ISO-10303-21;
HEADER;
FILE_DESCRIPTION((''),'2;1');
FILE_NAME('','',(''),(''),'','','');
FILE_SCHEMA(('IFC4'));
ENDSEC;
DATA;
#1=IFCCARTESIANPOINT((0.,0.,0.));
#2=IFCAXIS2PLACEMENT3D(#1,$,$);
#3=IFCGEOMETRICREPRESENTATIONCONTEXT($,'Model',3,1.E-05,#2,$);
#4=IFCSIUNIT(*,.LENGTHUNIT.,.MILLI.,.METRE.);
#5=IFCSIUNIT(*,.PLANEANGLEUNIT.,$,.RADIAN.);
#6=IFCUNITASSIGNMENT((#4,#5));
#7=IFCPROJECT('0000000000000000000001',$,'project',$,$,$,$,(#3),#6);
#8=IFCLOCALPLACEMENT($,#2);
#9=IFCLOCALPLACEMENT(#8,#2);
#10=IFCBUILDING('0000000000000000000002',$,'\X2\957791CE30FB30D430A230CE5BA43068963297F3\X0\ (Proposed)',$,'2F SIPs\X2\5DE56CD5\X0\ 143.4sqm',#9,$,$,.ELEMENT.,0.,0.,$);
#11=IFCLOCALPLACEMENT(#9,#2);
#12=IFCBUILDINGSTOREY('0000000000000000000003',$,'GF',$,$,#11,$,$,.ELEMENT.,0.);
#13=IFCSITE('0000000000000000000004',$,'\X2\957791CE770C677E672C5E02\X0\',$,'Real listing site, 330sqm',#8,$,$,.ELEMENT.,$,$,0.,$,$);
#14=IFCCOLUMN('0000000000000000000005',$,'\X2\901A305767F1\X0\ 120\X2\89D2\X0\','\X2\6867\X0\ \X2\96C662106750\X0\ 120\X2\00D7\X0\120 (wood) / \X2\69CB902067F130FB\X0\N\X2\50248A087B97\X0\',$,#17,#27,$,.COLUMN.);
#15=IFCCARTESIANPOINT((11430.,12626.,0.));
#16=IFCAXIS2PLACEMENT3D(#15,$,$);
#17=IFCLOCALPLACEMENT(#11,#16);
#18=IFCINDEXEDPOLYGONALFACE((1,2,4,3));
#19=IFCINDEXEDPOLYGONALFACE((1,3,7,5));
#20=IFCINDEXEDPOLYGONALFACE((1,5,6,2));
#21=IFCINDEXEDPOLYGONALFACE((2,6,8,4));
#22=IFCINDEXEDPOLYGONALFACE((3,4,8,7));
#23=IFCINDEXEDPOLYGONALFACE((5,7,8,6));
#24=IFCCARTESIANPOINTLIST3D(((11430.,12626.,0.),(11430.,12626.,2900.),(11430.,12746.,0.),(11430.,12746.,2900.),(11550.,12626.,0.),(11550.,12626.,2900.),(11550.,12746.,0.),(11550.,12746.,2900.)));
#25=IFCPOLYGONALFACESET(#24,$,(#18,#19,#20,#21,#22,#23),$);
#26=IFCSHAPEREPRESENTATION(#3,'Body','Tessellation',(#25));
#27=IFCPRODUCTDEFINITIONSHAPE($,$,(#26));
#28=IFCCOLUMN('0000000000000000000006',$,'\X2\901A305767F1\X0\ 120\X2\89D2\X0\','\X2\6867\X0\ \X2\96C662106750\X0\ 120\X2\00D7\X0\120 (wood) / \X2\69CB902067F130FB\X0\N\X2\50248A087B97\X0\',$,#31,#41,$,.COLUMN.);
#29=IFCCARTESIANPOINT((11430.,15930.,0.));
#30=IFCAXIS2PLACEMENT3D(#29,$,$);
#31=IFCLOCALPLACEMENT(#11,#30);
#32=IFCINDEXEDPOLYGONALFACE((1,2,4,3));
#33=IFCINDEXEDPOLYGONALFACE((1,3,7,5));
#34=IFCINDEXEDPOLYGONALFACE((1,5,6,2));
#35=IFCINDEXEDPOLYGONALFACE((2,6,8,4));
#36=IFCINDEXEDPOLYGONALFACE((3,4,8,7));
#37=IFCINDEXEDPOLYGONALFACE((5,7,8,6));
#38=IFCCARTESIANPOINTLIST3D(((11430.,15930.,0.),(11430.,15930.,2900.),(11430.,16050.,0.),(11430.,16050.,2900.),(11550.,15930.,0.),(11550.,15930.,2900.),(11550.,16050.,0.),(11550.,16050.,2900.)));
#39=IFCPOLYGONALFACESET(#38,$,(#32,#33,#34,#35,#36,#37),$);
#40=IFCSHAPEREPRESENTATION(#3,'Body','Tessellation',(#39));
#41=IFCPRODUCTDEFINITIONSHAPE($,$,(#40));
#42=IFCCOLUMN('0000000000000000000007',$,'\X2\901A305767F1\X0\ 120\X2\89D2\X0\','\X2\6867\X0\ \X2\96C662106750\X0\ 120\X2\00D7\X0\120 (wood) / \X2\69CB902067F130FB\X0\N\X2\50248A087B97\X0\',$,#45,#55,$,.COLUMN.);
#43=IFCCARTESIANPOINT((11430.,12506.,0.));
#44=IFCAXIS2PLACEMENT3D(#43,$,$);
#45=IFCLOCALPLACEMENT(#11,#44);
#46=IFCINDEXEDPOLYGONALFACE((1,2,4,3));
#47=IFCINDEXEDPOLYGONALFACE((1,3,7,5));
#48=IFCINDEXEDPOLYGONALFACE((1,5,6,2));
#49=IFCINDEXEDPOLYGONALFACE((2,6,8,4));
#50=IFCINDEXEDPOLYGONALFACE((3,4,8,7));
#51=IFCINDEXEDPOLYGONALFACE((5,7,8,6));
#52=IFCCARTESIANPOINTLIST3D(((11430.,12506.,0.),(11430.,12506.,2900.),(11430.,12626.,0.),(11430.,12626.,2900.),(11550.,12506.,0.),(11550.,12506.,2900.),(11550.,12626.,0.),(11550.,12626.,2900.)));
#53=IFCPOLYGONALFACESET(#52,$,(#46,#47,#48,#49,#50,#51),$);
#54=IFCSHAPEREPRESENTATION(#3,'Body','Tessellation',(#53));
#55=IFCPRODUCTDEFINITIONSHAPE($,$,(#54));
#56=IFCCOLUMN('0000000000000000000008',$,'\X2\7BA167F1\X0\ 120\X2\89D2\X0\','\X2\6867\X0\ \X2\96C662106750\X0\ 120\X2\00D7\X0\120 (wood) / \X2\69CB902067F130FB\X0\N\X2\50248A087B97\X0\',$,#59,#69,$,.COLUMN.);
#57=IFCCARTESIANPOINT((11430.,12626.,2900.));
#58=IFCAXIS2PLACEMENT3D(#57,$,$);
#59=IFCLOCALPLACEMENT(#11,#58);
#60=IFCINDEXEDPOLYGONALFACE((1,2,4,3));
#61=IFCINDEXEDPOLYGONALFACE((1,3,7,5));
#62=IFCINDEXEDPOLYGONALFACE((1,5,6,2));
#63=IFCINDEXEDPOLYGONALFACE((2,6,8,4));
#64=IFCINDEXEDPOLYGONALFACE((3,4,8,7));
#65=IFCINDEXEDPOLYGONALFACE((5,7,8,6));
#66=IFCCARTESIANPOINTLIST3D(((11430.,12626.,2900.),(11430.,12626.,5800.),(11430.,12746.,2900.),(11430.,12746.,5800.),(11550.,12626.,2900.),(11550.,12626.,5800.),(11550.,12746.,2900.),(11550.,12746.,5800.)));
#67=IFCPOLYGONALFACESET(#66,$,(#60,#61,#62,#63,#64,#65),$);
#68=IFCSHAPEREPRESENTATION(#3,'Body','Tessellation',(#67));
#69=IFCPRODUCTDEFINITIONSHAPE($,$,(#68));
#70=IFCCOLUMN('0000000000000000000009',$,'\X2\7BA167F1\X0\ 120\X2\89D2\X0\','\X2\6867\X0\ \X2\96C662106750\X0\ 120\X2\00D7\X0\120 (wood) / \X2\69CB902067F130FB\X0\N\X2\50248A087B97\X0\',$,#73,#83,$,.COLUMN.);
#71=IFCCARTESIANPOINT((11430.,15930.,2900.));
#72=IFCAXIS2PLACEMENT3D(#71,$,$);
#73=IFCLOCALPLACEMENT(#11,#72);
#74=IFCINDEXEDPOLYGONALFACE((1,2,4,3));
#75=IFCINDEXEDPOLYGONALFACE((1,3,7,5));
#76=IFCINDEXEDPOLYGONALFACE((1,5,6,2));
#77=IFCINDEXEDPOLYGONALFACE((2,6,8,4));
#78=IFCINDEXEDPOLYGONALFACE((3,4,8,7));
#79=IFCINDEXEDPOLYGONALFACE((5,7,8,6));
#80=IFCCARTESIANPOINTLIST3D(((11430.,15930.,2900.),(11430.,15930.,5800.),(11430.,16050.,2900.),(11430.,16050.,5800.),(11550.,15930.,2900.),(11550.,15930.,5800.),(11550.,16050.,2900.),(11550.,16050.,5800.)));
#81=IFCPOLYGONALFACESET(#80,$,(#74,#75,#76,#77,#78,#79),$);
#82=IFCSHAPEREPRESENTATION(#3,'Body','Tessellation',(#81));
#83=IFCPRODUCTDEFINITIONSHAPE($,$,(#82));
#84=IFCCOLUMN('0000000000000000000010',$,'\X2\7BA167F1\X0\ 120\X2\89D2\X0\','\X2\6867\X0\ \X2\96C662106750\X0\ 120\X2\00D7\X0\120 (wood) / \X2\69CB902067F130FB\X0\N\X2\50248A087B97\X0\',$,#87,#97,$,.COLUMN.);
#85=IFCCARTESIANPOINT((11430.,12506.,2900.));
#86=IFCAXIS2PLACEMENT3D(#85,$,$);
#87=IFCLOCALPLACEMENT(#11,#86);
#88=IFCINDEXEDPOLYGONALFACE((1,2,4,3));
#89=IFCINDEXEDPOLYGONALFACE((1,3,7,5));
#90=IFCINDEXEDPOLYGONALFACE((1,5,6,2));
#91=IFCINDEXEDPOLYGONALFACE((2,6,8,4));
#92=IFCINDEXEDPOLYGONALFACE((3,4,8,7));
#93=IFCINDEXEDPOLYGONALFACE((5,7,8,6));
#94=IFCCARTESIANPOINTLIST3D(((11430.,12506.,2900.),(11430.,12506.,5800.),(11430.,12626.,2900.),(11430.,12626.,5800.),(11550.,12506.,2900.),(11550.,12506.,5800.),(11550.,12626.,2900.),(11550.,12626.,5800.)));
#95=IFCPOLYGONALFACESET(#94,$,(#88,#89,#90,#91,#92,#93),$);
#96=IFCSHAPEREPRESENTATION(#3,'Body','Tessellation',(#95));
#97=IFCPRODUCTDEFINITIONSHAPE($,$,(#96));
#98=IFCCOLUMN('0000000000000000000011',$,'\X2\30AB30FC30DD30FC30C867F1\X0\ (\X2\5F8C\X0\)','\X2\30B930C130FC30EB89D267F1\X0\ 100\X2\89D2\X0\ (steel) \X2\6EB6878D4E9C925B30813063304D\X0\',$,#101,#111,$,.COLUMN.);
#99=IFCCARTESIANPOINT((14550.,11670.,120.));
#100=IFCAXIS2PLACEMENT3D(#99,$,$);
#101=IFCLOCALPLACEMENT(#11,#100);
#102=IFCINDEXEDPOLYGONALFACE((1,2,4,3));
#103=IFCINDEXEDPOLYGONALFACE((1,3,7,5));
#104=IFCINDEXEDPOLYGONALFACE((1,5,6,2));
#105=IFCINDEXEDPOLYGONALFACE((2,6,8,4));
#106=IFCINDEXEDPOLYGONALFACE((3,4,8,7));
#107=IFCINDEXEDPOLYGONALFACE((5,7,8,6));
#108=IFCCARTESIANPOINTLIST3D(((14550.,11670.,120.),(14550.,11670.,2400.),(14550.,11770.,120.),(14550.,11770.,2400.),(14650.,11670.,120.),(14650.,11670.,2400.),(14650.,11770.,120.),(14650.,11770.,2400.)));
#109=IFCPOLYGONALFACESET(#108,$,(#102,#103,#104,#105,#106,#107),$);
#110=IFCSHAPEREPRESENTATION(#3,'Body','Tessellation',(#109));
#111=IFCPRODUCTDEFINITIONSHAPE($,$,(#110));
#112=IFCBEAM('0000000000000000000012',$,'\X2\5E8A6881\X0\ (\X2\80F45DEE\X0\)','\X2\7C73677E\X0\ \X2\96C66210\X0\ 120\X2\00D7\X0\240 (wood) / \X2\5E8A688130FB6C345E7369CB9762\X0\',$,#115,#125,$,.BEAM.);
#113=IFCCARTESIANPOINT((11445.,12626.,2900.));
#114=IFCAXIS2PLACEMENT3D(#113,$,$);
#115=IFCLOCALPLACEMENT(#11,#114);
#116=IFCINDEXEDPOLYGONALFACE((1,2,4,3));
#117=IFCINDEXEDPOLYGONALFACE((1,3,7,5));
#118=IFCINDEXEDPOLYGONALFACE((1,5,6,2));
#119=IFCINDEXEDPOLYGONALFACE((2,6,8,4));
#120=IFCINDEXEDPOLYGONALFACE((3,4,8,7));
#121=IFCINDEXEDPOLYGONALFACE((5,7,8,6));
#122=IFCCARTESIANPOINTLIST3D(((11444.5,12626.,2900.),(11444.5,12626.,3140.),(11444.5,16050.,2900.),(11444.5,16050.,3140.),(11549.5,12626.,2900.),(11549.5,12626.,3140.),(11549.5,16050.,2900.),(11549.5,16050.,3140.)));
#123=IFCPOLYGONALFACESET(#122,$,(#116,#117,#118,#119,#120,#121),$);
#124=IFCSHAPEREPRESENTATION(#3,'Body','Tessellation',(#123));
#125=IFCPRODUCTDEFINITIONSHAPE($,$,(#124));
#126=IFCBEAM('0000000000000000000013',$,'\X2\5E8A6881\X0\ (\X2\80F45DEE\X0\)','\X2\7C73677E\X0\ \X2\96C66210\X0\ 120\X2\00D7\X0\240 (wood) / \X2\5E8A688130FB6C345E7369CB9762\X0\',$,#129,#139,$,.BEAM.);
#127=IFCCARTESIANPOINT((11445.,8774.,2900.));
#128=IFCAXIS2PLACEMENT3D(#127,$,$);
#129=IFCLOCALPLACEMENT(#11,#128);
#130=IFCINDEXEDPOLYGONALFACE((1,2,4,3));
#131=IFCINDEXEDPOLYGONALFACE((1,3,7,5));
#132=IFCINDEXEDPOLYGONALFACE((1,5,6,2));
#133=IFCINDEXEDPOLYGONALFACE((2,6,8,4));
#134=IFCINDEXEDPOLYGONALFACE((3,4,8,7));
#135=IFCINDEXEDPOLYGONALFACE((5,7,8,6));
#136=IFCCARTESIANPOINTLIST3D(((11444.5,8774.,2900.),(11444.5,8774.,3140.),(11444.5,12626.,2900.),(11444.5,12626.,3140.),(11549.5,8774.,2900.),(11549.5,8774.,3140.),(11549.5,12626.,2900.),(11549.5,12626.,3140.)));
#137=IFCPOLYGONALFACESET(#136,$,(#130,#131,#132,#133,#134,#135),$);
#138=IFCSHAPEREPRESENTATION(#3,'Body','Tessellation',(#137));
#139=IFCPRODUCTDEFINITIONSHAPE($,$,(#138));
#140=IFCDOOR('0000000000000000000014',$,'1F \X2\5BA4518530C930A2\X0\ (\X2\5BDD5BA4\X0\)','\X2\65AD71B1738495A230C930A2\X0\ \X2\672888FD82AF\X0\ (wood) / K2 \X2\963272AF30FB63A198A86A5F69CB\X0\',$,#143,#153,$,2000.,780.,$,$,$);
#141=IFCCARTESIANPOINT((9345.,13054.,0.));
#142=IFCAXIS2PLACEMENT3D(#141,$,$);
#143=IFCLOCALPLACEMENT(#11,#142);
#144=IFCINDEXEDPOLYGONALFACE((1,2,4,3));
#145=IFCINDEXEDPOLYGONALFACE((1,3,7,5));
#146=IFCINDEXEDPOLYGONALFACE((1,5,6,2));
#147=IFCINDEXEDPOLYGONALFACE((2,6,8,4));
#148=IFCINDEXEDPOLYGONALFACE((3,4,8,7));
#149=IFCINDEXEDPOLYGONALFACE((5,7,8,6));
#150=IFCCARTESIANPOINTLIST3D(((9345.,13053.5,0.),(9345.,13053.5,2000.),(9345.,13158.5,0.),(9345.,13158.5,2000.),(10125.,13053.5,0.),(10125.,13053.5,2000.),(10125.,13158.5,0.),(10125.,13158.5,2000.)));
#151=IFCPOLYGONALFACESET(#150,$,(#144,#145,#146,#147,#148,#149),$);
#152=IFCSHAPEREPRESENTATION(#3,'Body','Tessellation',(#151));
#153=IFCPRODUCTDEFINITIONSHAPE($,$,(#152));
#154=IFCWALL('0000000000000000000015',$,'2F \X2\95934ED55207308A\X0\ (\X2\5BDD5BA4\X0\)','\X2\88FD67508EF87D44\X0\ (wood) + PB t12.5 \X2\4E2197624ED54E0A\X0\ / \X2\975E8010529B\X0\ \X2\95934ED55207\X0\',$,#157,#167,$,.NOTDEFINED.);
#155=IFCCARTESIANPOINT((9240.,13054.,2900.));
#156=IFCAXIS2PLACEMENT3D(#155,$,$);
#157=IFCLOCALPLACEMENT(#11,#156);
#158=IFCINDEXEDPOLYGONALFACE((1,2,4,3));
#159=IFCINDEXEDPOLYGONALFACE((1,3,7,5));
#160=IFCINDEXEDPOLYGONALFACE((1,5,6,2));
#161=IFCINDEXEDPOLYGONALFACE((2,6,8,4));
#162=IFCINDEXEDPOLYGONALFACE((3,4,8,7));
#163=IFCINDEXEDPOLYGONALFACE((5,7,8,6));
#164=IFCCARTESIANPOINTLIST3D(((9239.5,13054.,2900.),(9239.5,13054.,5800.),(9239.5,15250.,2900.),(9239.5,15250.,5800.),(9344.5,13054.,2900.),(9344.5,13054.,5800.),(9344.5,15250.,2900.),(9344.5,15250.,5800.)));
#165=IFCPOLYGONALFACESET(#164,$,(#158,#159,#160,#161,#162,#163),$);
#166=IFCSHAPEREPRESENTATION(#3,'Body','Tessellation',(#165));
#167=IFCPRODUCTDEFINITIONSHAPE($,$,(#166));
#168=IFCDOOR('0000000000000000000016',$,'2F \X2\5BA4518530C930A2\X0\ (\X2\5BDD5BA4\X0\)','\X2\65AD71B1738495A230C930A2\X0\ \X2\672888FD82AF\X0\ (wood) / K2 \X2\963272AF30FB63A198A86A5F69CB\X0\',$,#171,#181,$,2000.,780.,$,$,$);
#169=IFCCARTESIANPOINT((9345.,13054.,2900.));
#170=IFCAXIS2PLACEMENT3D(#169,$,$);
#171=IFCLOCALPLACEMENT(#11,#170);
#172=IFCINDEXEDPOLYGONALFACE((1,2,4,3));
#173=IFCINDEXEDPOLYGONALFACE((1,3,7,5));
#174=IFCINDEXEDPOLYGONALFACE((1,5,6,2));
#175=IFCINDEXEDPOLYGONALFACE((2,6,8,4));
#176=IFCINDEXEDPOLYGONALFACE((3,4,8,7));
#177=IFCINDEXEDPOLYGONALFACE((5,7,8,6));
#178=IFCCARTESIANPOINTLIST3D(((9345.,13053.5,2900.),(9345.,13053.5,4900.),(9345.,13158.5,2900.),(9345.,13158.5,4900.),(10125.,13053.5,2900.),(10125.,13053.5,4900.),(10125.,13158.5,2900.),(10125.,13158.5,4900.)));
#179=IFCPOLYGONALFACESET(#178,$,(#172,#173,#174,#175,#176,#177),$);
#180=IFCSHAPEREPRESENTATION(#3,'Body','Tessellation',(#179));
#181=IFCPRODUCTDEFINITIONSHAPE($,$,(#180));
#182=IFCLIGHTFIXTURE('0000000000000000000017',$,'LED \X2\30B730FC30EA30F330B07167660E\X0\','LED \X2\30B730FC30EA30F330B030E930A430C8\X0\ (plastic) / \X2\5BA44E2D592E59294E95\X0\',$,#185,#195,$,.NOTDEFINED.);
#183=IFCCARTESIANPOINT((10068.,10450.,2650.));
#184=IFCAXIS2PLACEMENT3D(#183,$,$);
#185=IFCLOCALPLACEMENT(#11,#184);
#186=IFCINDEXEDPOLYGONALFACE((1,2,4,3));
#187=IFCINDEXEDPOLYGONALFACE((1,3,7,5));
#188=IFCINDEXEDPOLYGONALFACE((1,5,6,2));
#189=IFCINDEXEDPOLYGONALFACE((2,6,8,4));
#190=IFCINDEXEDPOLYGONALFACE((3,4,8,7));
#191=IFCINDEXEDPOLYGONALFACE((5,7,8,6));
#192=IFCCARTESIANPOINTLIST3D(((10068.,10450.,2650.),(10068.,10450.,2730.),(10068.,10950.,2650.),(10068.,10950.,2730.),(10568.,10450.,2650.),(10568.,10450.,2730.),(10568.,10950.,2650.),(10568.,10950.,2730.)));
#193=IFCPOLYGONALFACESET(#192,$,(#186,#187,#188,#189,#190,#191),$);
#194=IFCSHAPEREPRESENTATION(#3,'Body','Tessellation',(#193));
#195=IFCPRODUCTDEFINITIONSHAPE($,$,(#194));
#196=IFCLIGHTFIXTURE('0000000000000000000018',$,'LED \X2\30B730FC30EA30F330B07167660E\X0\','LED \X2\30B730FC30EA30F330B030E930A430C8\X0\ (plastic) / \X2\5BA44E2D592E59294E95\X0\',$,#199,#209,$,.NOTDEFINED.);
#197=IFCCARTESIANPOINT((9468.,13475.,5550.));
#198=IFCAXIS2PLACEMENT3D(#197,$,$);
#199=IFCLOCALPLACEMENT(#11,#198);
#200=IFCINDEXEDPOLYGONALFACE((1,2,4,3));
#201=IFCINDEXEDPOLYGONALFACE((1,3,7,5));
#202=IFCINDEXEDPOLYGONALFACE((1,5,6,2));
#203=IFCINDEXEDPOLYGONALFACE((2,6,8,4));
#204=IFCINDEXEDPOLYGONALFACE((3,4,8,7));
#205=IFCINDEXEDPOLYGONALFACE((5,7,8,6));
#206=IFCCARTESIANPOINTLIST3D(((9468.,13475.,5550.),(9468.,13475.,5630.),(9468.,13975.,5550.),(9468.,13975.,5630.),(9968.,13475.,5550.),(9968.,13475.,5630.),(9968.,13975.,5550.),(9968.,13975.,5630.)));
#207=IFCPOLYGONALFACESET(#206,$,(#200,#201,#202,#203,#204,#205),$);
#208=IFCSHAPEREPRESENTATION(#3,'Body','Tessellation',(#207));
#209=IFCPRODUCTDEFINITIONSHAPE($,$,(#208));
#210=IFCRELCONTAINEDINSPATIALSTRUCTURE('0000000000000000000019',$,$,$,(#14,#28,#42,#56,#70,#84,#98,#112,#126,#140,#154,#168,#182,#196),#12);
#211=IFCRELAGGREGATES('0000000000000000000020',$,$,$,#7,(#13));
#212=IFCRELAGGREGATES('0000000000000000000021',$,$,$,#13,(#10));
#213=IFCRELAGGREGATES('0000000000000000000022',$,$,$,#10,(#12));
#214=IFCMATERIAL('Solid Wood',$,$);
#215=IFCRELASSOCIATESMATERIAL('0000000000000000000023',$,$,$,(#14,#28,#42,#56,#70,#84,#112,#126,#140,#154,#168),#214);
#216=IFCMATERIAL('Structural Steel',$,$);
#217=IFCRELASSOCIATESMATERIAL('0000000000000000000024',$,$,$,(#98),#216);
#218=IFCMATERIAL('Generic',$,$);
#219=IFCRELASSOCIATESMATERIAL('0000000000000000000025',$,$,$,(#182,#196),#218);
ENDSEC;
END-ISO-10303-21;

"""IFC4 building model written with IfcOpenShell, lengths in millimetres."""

from ifc_helpers import new_model, si_unit, frame, frame_2d, origin, place, context, project, spatial, rectangle, extrude, material, element, save


model = new_model("IFC4")

# Units and contexts
model_context = context("Model", 3, precision=1e-05, world=origin())
ifc_project = project(units=[si_unit("LENGTHUNIT", "METRE", prefix="MILLI"), si_unit("PLANEANGLEUNIT", "RADIAN")], contexts=[model_context])

# Site, building, storey
site_placement = place(None, origin())
site = spatial("IfcSite", under=ifc_project, at=site_placement, Name="長野県松本市", ObjectType="Real listing site, 330sqm", CompositionType="ELEMENT", RefElevation=0.0)
building_placement = place(site_placement, origin())
building = spatial("IfcBuilding", under=site, at=building_placement, Name="長野・ピアノ室と防音 (Proposed)", ObjectType="2F SIPs工法 143.4sqm", CompositionType="ELEMENT", ElevationOfRefHeight=0.0, ElevationOfTerrain=0.0)
storey_placement = place(building_placement, origin())
storey = spatial("IfcBuildingStorey", under=building, at=storey_placement, Name="GF", CompositionType="ELEMENT", Elevation=0.0)

# Columns
ifc_material_1 = material(Name="Solid Wood")
column_1_placement = place(storey_placement, frame((11430.0, 12626.0, 0.0)))
element("IfcColumn", 1, at=column_1_placement, inside=storey, material=ifc_material_1, Name="通し柱 120角", Description="桧 集成材 120×120 (wood) / 構造柱・N値計算", PredefinedType="COLUMN", context=model_context, shape_type="SweptSolid", body=[
    extrude(rectangle(XDim=120.0, YDim=120.0, at=frame_2d((60.0, 60.0))), frame((11430.0, 12626.0, 0.0)), (0.0, 0.0, 1.0), 2900.0),
])
column_2_placement = place(storey_placement, frame((11430.0, 15930.0, 0.0)))
element("IfcColumn", 2, at=column_2_placement, inside=storey, material=ifc_material_1, Name="通し柱 120角", Description="桧 集成材 120×120 (wood) / 構造柱・N値計算", PredefinedType="COLUMN", context=model_context, shape_type="SweptSolid", body=[
    extrude(rectangle(XDim=120.0, YDim=120.0, at=frame_2d((60.0, 60.0))), frame((11430.0, 15930.0, 0.0)), (0.0, 0.0, 1.0), 2900.0),
])
column_3_placement = place(storey_placement, frame((11430.0, 12506.0, 0.0)))
element("IfcColumn", 3, at=column_3_placement, inside=storey, material=ifc_material_1, Name="通し柱 120角", Description="桧 集成材 120×120 (wood) / 構造柱・N値計算", PredefinedType="COLUMN", context=model_context, shape_type="SweptSolid", body=[
    extrude(rectangle(XDim=120.0, YDim=120.0, at=frame_2d((60.0, 60.0))), frame((11430.0, 12506.0, 0.0)), (0.0, 0.0, 1.0), 2900.0),
])
column_4_placement = place(storey_placement, frame((11430.0, 12626.0, 2900.0)))
element("IfcColumn", 4, at=column_4_placement, inside=storey, material=ifc_material_1, Name="管柱 120角", Description="桧 集成材 120×120 (wood) / 構造柱・N値計算", PredefinedType="COLUMN", context=model_context, shape_type="SweptSolid", body=[
    extrude(rectangle(XDim=120.0, YDim=120.0, at=frame_2d((60.0, 60.0))), frame((11430.0, 12626.0, 2900.0)), (0.0, 0.0, 1.0), 2900.0),
])
column_5_placement = place(storey_placement, frame((11430.0, 15930.0, 2900.0)))
element("IfcColumn", 5, at=column_5_placement, inside=storey, material=ifc_material_1, Name="管柱 120角", Description="桧 集成材 120×120 (wood) / 構造柱・N値計算", PredefinedType="COLUMN", context=model_context, shape_type="SweptSolid", body=[
    extrude(rectangle(XDim=120.0, YDim=120.0, at=frame_2d((60.0, 60.0))), frame((11430.0, 15930.0, 2900.0)), (0.0, 0.0, 1.0), 2900.0),
])
column_6_placement = place(storey_placement, frame((11430.0, 12506.0, 2900.0)))
element("IfcColumn", 6, at=column_6_placement, inside=storey, material=ifc_material_1, Name="管柱 120角", Description="桧 集成材 120×120 (wood) / 構造柱・N値計算", PredefinedType="COLUMN", context=model_context, shape_type="SweptSolid", body=[
    extrude(rectangle(XDim=120.0, YDim=120.0, at=frame_2d((60.0, 60.0))), frame((11430.0, 12506.0, 2900.0)), (0.0, 0.0, 1.0), 2900.0),
])
ifc_material_2 = material(Name="Structural Steel")
column_7_placement = place(storey_placement, frame((14550.0, 11670.0, 120.0)))
element("IfcColumn", 7, at=column_7_placement, inside=storey, material=ifc_material_2, Name="カーポート柱 (後)", Description="スチール角柱 100角 (steel) 溶融亜鉛めっき", PredefinedType="COLUMN", context=model_context, shape_type="SweptSolid", body=[
    extrude(rectangle(XDim=100.0, YDim=100.0, at=frame_2d((50.0, 50.0))), frame((14550.0, 11670.0, 120.0)), (0.0, 0.0, 1.0), 2280.0),
])

# Beams
beam_1_placement = place(storey_placement, frame((11445.0, 12626.0, 2900.0)))
element("IfcBeam", 8, at=beam_1_placement, inside=storey, material=ifc_material_1, Name="床梁 (胴差)", Description="米松 集成 120×240 (wood) / 床梁・水平構面", PredefinedType="BEAM", context=model_context, shape_type="SweptSolid", body=[
    extrude(rectangle(XDim=105.0, YDim=3424.0, at=frame_2d((52.0, 1712.0))), frame((11445.0, 12626.0, 2900.0)), (0.0, 0.0, 1.0), 240.0),
])
beam_2_placement = place(storey_placement, frame((11445.0, 8774.0, 2900.0)))
element("IfcBeam", 9, at=beam_2_placement, inside=storey, material=ifc_material_1, Name="床梁 (胴差)", Description="米松 集成 120×240 (wood) / 床梁・水平構面", PredefinedType="BEAM", context=model_context, shape_type="SweptSolid", body=[
    extrude(rectangle(XDim=105.0, YDim=3852.0, at=frame_2d((52.0, 1926.0))), frame((11445.0, 8774.0, 2900.0)), (0.0, 0.0, 1.0), 240.0),
])

# Door
door_1_placement = place(storey_placement, frame((9345.0, 13054.0, 0.0)))
element("IfcDoor", 10, at=door_1_placement, inside=storey, material=ifc_material_1, Name="1F 室内ドア (寝室)", Description="断熱玄関ドア 木製芯 (wood) / K2 防犯・採風機構", OverallHeight=2000.0, OverallWidth=780.0, context=model_context, shape_type="SweptSolid", body=[
    extrude(rectangle(XDim=780.0, YDim=105.0, at=frame_2d((390.0, 52.0))), frame((9345.0, 13054.0, 0.0)), (0.0, 0.0, 1.0), 2000.0),
])

# Wall
wall_placement = place(storey_placement, frame((9240.0, 13054.0, 2900.0)))
element("IfcWall", 11, at=wall_placement, inside=storey, material=ifc_material_1, Name="2F 間仕切り (寝室)", Description="製材軸組 (wood) + PB t12.5 両面仕上 / 非耐力 間仕切", PredefinedType="NOTDEFINED", context=model_context, shape_type="SweptSolid", body=[
    extrude(rectangle(XDim=105.0, YDim=2196.0, at=frame_2d((52.0, 1098.0))), frame((9240.0, 13054.0, 2900.0)), (0.0, 0.0, 1.0), 2900.0),
])

# Door
door_2_placement = place(storey_placement, frame((9345.0, 13054.0, 2900.0)))
element("IfcDoor", 12, at=door_2_placement, inside=storey, material=ifc_material_1, Name="2F 室内ドア (寝室)", Description="断熱玄関ドア 木製芯 (wood) / K2 防犯・採風機構", OverallHeight=2000.0, OverallWidth=780.0, context=model_context, shape_type="SweptSolid", body=[
    extrude(rectangle(XDim=780.0, YDim=105.0, at=frame_2d((390.0, 52.0))), frame((9345.0, 13054.0, 2900.0)), (0.0, 0.0, 1.0), 2000.0),
])

# Light fixtures
ifc_material_3 = material(Name="Generic")
light_fixture_1_placement = place(storey_placement, frame((10068.0, 10450.0, 2650.0)))
element("IfcLightFixture", 13, at=light_fixture_1_placement, inside=storey, material=ifc_material_3, Name="LED シーリング照明", Description="LED シーリングライト (plastic) / 室中央天井", PredefinedType="NOTDEFINED", context=model_context, shape_type="SweptSolid", body=[
    extrude(rectangle(XDim=500.0, YDim=500.0, at=frame_2d((250.0, 250.0))), frame((10068.0, 10450.0, 2650.0)), (0.0, 0.0, 1.0), 80.0),
])
light_fixture_2_placement = place(storey_placement, frame((9468.0, 13475.0, 5550.0)))
element("IfcLightFixture", 14, at=light_fixture_2_placement, inside=storey, material=ifc_material_3, Name="LED シーリング照明", Description="LED シーリングライト (plastic) / 室中央天井", PredefinedType="NOTDEFINED", context=model_context, shape_type="SweptSolid", body=[
    extrude(rectangle(XDim=500.0, YDim=500.0, at=frame_2d((250.0, 250.0))), frame((9468.0, 13475.0, 5550.0)), (0.0, 0.0, 1.0), 80.0),
])

save(model, "model.ifc")
